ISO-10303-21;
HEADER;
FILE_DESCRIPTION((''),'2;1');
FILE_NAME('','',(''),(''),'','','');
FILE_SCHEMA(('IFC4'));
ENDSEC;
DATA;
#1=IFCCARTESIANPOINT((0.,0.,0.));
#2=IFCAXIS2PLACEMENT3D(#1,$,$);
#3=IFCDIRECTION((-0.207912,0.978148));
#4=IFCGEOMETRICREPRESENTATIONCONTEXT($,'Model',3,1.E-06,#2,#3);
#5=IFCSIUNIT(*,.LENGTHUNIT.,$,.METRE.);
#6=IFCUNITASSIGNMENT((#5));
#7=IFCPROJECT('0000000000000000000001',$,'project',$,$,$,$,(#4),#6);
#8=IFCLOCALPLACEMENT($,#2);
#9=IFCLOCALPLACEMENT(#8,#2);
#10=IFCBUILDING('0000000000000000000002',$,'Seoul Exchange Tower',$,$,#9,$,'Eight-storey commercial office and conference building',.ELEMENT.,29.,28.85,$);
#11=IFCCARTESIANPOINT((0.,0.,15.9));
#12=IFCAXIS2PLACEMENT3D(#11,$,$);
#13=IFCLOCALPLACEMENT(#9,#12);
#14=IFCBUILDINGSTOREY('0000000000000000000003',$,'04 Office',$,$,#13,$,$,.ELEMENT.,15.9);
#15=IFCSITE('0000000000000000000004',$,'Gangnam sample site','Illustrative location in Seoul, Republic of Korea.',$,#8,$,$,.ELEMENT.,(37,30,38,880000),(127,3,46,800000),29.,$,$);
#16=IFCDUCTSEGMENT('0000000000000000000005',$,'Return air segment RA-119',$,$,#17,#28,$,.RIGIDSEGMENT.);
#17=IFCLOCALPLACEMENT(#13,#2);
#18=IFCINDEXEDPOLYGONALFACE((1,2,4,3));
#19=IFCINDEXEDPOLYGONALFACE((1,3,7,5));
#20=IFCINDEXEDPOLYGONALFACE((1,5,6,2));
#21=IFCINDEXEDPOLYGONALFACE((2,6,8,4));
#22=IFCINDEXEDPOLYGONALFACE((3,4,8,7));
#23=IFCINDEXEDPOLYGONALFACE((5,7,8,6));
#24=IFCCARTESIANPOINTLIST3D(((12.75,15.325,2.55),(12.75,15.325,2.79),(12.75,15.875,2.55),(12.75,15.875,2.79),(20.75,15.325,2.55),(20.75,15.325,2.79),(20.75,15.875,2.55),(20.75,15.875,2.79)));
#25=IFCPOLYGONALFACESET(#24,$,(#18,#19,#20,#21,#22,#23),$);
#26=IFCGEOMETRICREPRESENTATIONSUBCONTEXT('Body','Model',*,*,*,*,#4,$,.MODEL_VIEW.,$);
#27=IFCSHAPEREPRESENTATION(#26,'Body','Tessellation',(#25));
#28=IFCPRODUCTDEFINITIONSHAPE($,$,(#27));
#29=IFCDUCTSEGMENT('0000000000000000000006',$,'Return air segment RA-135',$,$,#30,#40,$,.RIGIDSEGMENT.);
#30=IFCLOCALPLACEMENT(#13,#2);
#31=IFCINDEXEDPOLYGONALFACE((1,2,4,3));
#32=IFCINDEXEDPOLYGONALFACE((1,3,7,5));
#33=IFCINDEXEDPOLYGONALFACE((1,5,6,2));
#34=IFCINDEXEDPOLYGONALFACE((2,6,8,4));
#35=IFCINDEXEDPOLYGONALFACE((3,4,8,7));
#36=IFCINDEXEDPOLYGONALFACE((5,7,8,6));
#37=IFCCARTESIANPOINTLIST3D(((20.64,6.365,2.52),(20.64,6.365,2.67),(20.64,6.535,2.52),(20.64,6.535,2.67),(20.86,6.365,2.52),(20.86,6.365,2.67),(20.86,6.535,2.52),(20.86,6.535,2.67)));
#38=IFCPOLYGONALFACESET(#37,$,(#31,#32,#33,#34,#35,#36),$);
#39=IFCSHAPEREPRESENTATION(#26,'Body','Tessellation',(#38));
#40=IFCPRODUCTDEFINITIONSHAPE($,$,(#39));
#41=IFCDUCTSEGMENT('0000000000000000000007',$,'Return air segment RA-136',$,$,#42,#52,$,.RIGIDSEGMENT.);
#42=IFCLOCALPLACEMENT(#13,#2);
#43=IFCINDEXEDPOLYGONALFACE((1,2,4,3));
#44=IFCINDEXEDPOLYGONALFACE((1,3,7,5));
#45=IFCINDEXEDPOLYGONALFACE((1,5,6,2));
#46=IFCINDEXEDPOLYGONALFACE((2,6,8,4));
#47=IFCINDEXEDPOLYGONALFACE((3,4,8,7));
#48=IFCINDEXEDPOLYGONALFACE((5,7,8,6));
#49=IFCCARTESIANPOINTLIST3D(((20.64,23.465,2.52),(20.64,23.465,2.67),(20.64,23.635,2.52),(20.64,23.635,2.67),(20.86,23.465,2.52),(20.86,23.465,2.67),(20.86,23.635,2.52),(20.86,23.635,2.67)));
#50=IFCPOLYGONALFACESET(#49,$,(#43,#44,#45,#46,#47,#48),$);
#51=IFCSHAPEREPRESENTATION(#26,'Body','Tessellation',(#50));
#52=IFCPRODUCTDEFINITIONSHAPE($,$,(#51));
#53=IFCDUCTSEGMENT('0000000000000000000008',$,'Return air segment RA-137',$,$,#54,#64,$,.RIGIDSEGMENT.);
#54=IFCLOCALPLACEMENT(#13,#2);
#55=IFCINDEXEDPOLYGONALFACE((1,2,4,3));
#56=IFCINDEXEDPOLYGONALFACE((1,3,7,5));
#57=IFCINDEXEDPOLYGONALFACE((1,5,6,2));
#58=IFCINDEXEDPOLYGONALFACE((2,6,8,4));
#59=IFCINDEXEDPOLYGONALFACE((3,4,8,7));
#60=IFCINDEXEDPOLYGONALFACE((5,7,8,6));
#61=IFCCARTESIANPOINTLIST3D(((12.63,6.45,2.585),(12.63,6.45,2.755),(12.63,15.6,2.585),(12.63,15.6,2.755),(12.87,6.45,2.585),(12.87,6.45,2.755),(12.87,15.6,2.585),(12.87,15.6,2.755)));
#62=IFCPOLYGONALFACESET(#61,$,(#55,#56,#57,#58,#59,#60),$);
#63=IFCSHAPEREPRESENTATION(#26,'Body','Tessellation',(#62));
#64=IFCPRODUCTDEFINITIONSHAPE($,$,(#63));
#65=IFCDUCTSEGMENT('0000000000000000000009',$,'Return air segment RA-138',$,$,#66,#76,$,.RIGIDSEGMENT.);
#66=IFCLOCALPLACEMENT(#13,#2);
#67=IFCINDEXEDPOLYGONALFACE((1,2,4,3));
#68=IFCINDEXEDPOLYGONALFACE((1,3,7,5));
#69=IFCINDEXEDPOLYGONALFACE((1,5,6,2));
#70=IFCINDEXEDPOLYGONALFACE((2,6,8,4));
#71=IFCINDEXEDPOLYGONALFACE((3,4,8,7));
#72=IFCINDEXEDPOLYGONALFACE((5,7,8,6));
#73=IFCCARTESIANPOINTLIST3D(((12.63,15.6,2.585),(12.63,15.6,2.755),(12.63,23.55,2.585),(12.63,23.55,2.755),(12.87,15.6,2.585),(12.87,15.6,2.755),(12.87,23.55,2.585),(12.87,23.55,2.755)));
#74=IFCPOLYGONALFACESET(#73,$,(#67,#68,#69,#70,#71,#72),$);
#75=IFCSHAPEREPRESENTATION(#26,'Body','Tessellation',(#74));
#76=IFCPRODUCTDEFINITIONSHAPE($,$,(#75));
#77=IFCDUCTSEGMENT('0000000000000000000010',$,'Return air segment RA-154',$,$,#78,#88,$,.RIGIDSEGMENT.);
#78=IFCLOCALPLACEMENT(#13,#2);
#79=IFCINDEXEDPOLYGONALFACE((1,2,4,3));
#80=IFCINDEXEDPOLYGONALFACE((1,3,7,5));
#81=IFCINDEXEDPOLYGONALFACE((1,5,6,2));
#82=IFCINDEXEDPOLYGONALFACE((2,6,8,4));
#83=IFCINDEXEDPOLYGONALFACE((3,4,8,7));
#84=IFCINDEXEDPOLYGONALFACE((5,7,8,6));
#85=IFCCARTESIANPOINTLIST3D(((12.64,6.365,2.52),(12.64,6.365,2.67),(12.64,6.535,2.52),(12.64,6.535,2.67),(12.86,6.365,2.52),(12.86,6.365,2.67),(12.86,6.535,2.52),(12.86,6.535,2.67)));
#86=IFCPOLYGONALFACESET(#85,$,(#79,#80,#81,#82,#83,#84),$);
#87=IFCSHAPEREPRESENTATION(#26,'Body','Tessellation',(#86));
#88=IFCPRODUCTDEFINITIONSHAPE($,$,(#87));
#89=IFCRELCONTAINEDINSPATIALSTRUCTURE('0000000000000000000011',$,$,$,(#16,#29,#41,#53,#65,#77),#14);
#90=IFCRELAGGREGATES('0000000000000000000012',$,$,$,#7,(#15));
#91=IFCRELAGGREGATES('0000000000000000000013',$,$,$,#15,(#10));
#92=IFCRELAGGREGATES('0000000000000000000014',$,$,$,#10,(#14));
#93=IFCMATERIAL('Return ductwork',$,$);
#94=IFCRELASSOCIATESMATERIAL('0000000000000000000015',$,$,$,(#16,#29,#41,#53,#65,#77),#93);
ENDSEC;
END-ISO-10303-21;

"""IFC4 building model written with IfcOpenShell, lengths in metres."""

from ifc_helpers import new_model, si_unit, direction, frame, origin, place, context, subcontext, project, spatial, rectangle, extrude, material, element, save


model = new_model("IFC4")

# Units and contexts
model_context = context("Model", 3, precision=1e-06, world=origin(), true_north=direction((-0.207912, 0.978148)))
body_context = subcontext(model_context, "Body", "Model", "MODEL_VIEW")
ifc_project = project(units=[si_unit("LENGTHUNIT", "METRE")], contexts=[model_context])

# Site, building, storey
site_placement = place(None, origin())
site = spatial("IfcSite", under=ifc_project, at=site_placement, Name="Gangnam sample site", Description="Illustrative location in Seoul, Republic of Korea.", CompositionType="ELEMENT", RefLatitude=(37, 30, 38, 880000), RefLongitude=(127, 3, 46, 800000), RefElevation=29.0)
building_placement = place(site_placement, origin())
building = spatial("IfcBuilding", under=site, at=building_placement, Name="Seoul Exchange Tower", LongName="Eight-storey commercial office and conference building", CompositionType="ELEMENT", ElevationOfRefHeight=29.0, ElevationOfTerrain=28.85)
storey_placement = place(building_placement, frame((0.0, 0.0, 15.9)))
storey = spatial("IfcBuildingStorey", under=building, at=storey_placement, Name="04 Office", CompositionType="ELEMENT", Elevation=15.9)

# Shared definitions
ifc_material = material(Name="Return ductwork")
placement = place(storey_placement, origin())

# Duct segments
element("IfcDuctSegment", 1, at=placement, inside=storey, material=ifc_material, Name="Return air segment RA-119", PredefinedType="RIGIDSEGMENT", context=body_context, shape_type="SweptSolid", body=[
    extrude(rectangle(XDim=0.55, YDim=0.24), frame((12.75, 15.6, 2.67), z_axis=(1.0, 0.0, 0.0), x_axis=(0.0, 1.0, 0.0)), (0.0, 0.0, 1.0), 8.0),
])
element("IfcDuctSegment", 2, at=placement, inside=storey, material=ifc_material, Name="Return air segment RA-135", PredefinedType="RIGIDSEGMENT", context=body_context, shape_type="SweptSolid", body=[
    extrude(rectangle(XDim=0.22, YDim=0.17), frame((20.75, 6.45, 2.52), z_axis=(0.0, 0.0, 1.0), x_axis=(1.0, 0.0, 0.0)), (0.0, 0.0, 1.0), 0.15),
])
element("IfcDuctSegment", 3, at=placement, inside=storey, material=ifc_material, Name="Return air segment RA-136", PredefinedType="RIGIDSEGMENT", context=body_context, shape_type="SweptSolid", body=[
    extrude(rectangle(XDim=0.22, YDim=0.17), frame((20.75, 23.55, 2.52), z_axis=(0.0, 0.0, 1.0), x_axis=(1.0, 0.0, 0.0)), (0.0, 0.0, 1.0), 0.15),
])
element("IfcDuctSegment", 4, at=placement, inside=storey, material=ifc_material, Name="Return air segment RA-137", PredefinedType="RIGIDSEGMENT", context=body_context, shape_type="SweptSolid", body=[
    extrude(rectangle(XDim=0.24, YDim=0.17), frame((12.75, 6.45, 2.67), z_axis=(0.0, 1.0, 0.0), x_axis=(1.0, 0.0, 0.0)), (0.0, 0.0, 1.0), 9.15),
])
element("IfcDuctSegment", 5, at=placement, inside=storey, material=ifc_material, Name="Return air segment RA-138", PredefinedType="RIGIDSEGMENT", context=body_context, shape_type="SweptSolid", body=[
    extrude(rectangle(XDim=0.24, YDim=0.17), frame((12.75, 23.55, 2.67), z_axis=(0.0, -1.0, 0.0), x_axis=(1.0, 0.0, 0.0)), (0.0, 0.0, 1.0), 7.95),
])
element("IfcDuctSegment", 6, at=placement, inside=storey, material=ifc_material, Name="Return air segment RA-154", PredefinedType="RIGIDSEGMENT", context=body_context, shape_type="SweptSolid", body=[
    extrude(rectangle(XDim=0.22, YDim=0.17), frame((12.75, 6.45, 2.52), z_axis=(0.0, 0.0, 1.0), x_axis=(1.0, 0.0, 0.0)), (0.0, 0.0, 1.0), 0.15),
])

save(model, "model.ifc")
